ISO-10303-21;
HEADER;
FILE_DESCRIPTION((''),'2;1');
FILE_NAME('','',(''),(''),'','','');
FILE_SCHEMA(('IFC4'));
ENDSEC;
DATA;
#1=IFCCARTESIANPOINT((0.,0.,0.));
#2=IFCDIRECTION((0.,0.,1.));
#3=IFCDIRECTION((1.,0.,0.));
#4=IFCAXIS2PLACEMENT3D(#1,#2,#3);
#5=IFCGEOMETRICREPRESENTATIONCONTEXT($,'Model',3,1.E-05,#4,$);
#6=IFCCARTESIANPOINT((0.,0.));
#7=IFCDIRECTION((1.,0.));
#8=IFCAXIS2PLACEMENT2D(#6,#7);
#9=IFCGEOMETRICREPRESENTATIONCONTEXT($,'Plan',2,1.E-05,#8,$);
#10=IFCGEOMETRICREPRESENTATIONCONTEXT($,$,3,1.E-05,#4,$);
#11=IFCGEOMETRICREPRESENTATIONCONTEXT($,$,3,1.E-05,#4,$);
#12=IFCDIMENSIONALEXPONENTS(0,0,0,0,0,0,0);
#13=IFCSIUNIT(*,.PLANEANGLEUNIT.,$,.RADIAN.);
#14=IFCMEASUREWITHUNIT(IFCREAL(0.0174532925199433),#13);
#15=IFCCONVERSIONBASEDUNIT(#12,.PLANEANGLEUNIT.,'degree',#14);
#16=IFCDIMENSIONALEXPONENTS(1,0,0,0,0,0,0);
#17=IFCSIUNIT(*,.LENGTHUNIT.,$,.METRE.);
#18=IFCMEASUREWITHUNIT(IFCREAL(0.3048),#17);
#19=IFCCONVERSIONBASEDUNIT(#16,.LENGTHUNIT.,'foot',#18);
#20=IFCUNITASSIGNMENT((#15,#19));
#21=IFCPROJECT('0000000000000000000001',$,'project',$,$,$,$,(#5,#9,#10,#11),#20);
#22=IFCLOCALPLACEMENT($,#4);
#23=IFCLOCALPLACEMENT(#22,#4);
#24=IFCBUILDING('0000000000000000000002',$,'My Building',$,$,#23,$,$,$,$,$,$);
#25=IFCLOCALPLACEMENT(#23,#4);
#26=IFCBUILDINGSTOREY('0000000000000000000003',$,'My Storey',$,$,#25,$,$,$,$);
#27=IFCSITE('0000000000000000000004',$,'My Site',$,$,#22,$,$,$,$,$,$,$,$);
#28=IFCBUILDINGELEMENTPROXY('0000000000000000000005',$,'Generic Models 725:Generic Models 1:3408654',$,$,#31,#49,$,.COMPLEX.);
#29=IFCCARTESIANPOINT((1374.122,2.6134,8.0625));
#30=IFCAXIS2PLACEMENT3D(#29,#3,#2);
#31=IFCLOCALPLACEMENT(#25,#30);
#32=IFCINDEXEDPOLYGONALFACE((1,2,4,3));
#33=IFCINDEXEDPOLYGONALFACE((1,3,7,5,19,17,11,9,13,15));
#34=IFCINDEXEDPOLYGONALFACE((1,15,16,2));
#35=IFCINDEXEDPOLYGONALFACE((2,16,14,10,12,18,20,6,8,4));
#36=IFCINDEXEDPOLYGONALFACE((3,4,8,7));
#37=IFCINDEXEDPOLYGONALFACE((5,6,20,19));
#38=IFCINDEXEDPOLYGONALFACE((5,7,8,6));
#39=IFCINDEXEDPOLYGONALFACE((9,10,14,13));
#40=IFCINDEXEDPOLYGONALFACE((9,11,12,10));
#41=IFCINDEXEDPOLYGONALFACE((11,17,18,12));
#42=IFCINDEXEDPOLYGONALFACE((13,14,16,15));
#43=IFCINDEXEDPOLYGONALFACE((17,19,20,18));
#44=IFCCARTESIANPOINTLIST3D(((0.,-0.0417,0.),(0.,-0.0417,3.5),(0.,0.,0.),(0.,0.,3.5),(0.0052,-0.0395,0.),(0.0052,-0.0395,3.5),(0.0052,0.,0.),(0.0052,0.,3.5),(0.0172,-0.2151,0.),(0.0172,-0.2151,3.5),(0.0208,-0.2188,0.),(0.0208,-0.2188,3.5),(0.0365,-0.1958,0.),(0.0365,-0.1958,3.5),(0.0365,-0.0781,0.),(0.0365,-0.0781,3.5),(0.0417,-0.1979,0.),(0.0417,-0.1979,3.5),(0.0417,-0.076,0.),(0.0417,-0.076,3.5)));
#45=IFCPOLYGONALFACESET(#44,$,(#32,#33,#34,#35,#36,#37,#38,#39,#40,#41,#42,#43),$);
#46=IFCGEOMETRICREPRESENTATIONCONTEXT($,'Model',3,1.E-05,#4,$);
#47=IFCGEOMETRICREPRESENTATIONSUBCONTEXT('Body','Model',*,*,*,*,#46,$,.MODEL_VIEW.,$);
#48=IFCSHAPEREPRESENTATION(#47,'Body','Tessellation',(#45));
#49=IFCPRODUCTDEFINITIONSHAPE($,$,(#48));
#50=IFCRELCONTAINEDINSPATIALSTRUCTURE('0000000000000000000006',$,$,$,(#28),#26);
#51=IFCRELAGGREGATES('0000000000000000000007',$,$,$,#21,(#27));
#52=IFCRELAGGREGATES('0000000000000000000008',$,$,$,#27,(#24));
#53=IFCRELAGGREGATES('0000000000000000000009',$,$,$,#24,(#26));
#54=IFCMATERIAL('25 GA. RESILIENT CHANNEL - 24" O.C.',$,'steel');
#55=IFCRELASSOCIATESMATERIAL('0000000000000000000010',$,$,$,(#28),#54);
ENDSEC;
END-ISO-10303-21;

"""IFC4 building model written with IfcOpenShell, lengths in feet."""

from ifc_helpers import new_model, entity, si_unit, converted_unit, frame, origin_with_axes, origin_2d_with_axis, place, context, subcontext, project, spatial, line, indexed_curve, outline, extrude, material, element, save


model = new_model("IFC4")

# Units and contexts
model_context_1 = context("Model", 3, precision=1e-05, world=origin_with_axes())
plan_context = context("Plan", 2, precision=1e-05, world=origin_2d_with_axis())
model_context_2 = context("Model", 3, precision=1e-05, world=origin_with_axes())
context_of_model_1 = context(None, 3, precision=1e-05, world=origin_with_axes())
context_of_model_2 = context(None, 3, precision=1e-05, world=origin_with_axes())
body_context = subcontext(model_context_2, "Body", "Model", "MODEL_VIEW")
ifc_project = project(units=[converted_unit("PLANEANGLEUNIT", "degree", entity("IfcReal", 0.0174532925199433), si_unit("PLANEANGLEUNIT", "RADIAN"), dimensions=[0, 0, 0, 0, 0, 0, 0]), converted_unit("LENGTHUNIT", "foot", entity("IfcReal", 0.3048), si_unit("LENGTHUNIT", "METRE"), dimensions=[1, 0, 0, 0, 0, 0, 0])], contexts=[model_context_1, plan_context, context_of_model_1, context_of_model_2])

# Site, building, storey
site_placement = place(None, origin_with_axes())
site = spatial("IfcSite", under=ifc_project, at=site_placement, Name="My Site")
building_placement = place(site_placement, origin_with_axes())
building = spatial("IfcBuilding", under=site, at=building_placement, Name="My Building")
storey_placement = place(building_placement, origin_with_axes())
storey = spatial("IfcBuildingStorey", under=building, at=storey_placement, Name="My Storey")

# Building element proxy
ifc_material_1 = material(Name="25 GA. RESILIENT CHANNEL - 24\" O.C.", Category="steel")
proxy_1_placement = place(storey_placement, frame((1374.122, 2.6134, 8.0625), z_axis=(1.0, 0.0, 0.0), x_axis=(0.0, 0.0, 1.0)))
element("IfcBuildingElementProxy", 1, at=proxy_1_placement, inside=storey, material=ifc_material_1, Name="Generic Models 725:Generic Models 1:3408654", PredefinedType="COMPLEX", context=body_context, shape_type="SweptSolid", body=[
    extrude(outline(indexed_curve([(0.0684, -0.0024), (0.1072, 0.0051), (0.1082, 0.0), (0.0673, -0.0079), (0.0246, 0.021), (-0.0909, -0.0012), (-0.1062, -0.0238), (-0.1105, -0.0209), (-0.094, 0.0035), (0.0258, 0.0266)], segments=[line(6, 5), line(5, 4), line(4, 3), line(3, 2), line(2, 1), line(1, 10), line(10, 9), line(9, 8), line(8, 7), line(7, 6)], self_intersect=False)), frame((0.0205, -0.1063, 0.0), z_axis=(0.0, 0.0, -1.0), x_axis=(-0.189091, 0.98196, 0.0)), (0.0, 0.0, -1.0), 3.5),
])

save(model, "model.ifc")
